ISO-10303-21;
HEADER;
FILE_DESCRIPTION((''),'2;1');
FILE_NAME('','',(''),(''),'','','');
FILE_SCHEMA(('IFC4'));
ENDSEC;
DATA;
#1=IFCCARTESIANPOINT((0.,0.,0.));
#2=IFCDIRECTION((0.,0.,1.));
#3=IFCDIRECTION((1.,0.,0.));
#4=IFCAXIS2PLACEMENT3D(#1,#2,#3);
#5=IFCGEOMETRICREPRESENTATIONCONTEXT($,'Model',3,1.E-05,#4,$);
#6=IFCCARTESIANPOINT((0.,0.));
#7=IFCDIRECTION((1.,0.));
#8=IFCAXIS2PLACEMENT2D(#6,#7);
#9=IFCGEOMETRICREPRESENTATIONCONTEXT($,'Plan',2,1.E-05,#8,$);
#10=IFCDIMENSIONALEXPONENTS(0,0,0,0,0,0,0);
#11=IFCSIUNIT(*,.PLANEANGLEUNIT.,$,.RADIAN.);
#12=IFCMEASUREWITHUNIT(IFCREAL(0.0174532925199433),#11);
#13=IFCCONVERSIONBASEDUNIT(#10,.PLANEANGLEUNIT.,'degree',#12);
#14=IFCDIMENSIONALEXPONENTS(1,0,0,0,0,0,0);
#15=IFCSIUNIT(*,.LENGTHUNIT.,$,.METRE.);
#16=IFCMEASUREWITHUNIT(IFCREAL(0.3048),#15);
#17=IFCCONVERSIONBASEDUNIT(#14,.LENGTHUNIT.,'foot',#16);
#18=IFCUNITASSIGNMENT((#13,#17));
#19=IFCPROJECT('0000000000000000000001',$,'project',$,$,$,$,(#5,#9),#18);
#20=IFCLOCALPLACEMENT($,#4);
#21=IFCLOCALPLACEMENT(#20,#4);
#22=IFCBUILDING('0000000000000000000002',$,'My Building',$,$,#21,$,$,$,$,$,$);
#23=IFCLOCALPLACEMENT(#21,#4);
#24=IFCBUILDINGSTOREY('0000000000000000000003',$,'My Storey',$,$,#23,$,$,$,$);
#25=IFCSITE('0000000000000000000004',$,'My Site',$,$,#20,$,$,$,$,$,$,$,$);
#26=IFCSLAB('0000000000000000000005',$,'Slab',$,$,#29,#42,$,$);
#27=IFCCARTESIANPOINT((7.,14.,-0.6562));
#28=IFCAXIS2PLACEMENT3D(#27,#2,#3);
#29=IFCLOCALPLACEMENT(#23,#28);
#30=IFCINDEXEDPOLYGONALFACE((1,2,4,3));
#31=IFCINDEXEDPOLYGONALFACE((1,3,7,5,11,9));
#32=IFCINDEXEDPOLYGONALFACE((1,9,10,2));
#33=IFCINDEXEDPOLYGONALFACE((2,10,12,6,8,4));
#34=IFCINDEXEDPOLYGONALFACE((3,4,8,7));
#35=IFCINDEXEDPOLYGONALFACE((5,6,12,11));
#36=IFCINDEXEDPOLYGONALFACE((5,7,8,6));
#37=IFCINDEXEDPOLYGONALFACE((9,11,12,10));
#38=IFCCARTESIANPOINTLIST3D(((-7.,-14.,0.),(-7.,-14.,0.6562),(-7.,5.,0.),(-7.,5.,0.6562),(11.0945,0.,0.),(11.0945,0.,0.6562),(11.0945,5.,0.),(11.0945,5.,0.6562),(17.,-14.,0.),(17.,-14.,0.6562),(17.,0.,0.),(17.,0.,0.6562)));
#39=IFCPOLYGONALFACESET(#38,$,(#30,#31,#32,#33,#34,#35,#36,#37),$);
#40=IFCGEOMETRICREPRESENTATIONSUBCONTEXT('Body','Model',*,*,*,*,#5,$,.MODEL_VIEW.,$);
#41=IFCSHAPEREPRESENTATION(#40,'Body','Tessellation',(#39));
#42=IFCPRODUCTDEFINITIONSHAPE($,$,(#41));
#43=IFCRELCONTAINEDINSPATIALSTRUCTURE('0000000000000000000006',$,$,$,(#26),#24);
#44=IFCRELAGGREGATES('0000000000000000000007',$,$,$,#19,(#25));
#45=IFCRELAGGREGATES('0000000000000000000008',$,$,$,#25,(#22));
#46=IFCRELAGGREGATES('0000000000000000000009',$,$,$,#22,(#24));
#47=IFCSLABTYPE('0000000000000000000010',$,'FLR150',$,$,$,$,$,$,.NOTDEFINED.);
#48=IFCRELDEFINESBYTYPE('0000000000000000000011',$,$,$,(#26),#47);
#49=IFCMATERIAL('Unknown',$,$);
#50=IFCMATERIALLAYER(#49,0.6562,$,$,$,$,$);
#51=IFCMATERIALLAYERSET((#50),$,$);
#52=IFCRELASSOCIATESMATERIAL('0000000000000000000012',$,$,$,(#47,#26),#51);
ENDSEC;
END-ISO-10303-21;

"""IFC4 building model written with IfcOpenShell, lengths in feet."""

from ifc_helpers import new_model, entity, si_unit, converted_unit, frame, origin_with_axes, origin_2d_with_axis, place, context, subcontext, project, spatial, line, indexed_curve, outline, extrude, material, layer, layer_set, layer_usage, type_object, element, save


model = new_model("IFC4")

# Units and contexts
model_context = context("Model", 3, precision=1e-05, world=origin_with_axes())
plan_context = context("Plan", 2, precision=1e-05, world=origin_2d_with_axis())
body_context_1 = subcontext(model_context, "Body", "Model", "MODEL_VIEW")
ifc_project = project(units=[converted_unit("PLANEANGLEUNIT", "degree", entity("IfcReal", 0.0174532925199433), si_unit("PLANEANGLEUNIT", "RADIAN"), dimensions=[0, 0, 0, 0, 0, 0, 0]), converted_unit("LENGTHUNIT", "foot", entity("IfcReal", 0.3048), si_unit("LENGTHUNIT", "METRE"), dimensions=[1, 0, 0, 0, 0, 0, 0])], contexts=[model_context, plan_context])

# Site, building, storey
site_placement = place(None, origin_with_axes())
site = spatial("IfcSite", under=ifc_project, at=site_placement, Name="My Site")
building_placement = place(site_placement, origin_with_axes())
building = spatial("IfcBuilding", under=site, at=building_placement, Name="My Building")
storey_placement = place(building_placement, origin_with_axes())
storey = spatial("IfcBuildingStorey", under=building, at=storey_placement, Name="My Storey")

# Shared definitions
ifc_material = material(Name="Unknown")

# Slab
ifc_layer_1 = layer(ifc_material, 0.6562)
ifc_layer_set_1 = layer_set([ifc_layer_1])
ifc_layer_usage_1 = layer_usage(ifc_layer_set_1, "AXIS3", "POSITIVE", 0.0)
slab_type = type_object("IfcSlabType", Name="FLR150", PredefinedType="NOTDEFINED", material=ifc_layer_set_1)
slab_placement = place(storey_placement, frame((7.0, 14.0, -0.6562), z_axis=(0.0, 0.0, 1.0), x_axis=(1.0, 0.0, 0.0)))
element("IfcSlab", 1, at=slab_placement, inside=storey, type_object=slab_type, material=ifc_layer_usage_1, Name="Slab", context=body_context_1, shape_type="SweptSolid", body=[
    extrude(outline(indexed_curve([(-7.0, 5.0), (-7.0, -14.0), (17.0, -14.0), (17.0, 0.0), (11.0945, 5.0), (11.0945, 0.0)], segments=[line(2, 1), line(1, 5), line(5, 6), line(6, 4), line(4, 3), line(3, 2)], self_intersect=False)), None, (0.0, 0.0, 1.0), 0.6562),
])

save(model, "model.ifc")
